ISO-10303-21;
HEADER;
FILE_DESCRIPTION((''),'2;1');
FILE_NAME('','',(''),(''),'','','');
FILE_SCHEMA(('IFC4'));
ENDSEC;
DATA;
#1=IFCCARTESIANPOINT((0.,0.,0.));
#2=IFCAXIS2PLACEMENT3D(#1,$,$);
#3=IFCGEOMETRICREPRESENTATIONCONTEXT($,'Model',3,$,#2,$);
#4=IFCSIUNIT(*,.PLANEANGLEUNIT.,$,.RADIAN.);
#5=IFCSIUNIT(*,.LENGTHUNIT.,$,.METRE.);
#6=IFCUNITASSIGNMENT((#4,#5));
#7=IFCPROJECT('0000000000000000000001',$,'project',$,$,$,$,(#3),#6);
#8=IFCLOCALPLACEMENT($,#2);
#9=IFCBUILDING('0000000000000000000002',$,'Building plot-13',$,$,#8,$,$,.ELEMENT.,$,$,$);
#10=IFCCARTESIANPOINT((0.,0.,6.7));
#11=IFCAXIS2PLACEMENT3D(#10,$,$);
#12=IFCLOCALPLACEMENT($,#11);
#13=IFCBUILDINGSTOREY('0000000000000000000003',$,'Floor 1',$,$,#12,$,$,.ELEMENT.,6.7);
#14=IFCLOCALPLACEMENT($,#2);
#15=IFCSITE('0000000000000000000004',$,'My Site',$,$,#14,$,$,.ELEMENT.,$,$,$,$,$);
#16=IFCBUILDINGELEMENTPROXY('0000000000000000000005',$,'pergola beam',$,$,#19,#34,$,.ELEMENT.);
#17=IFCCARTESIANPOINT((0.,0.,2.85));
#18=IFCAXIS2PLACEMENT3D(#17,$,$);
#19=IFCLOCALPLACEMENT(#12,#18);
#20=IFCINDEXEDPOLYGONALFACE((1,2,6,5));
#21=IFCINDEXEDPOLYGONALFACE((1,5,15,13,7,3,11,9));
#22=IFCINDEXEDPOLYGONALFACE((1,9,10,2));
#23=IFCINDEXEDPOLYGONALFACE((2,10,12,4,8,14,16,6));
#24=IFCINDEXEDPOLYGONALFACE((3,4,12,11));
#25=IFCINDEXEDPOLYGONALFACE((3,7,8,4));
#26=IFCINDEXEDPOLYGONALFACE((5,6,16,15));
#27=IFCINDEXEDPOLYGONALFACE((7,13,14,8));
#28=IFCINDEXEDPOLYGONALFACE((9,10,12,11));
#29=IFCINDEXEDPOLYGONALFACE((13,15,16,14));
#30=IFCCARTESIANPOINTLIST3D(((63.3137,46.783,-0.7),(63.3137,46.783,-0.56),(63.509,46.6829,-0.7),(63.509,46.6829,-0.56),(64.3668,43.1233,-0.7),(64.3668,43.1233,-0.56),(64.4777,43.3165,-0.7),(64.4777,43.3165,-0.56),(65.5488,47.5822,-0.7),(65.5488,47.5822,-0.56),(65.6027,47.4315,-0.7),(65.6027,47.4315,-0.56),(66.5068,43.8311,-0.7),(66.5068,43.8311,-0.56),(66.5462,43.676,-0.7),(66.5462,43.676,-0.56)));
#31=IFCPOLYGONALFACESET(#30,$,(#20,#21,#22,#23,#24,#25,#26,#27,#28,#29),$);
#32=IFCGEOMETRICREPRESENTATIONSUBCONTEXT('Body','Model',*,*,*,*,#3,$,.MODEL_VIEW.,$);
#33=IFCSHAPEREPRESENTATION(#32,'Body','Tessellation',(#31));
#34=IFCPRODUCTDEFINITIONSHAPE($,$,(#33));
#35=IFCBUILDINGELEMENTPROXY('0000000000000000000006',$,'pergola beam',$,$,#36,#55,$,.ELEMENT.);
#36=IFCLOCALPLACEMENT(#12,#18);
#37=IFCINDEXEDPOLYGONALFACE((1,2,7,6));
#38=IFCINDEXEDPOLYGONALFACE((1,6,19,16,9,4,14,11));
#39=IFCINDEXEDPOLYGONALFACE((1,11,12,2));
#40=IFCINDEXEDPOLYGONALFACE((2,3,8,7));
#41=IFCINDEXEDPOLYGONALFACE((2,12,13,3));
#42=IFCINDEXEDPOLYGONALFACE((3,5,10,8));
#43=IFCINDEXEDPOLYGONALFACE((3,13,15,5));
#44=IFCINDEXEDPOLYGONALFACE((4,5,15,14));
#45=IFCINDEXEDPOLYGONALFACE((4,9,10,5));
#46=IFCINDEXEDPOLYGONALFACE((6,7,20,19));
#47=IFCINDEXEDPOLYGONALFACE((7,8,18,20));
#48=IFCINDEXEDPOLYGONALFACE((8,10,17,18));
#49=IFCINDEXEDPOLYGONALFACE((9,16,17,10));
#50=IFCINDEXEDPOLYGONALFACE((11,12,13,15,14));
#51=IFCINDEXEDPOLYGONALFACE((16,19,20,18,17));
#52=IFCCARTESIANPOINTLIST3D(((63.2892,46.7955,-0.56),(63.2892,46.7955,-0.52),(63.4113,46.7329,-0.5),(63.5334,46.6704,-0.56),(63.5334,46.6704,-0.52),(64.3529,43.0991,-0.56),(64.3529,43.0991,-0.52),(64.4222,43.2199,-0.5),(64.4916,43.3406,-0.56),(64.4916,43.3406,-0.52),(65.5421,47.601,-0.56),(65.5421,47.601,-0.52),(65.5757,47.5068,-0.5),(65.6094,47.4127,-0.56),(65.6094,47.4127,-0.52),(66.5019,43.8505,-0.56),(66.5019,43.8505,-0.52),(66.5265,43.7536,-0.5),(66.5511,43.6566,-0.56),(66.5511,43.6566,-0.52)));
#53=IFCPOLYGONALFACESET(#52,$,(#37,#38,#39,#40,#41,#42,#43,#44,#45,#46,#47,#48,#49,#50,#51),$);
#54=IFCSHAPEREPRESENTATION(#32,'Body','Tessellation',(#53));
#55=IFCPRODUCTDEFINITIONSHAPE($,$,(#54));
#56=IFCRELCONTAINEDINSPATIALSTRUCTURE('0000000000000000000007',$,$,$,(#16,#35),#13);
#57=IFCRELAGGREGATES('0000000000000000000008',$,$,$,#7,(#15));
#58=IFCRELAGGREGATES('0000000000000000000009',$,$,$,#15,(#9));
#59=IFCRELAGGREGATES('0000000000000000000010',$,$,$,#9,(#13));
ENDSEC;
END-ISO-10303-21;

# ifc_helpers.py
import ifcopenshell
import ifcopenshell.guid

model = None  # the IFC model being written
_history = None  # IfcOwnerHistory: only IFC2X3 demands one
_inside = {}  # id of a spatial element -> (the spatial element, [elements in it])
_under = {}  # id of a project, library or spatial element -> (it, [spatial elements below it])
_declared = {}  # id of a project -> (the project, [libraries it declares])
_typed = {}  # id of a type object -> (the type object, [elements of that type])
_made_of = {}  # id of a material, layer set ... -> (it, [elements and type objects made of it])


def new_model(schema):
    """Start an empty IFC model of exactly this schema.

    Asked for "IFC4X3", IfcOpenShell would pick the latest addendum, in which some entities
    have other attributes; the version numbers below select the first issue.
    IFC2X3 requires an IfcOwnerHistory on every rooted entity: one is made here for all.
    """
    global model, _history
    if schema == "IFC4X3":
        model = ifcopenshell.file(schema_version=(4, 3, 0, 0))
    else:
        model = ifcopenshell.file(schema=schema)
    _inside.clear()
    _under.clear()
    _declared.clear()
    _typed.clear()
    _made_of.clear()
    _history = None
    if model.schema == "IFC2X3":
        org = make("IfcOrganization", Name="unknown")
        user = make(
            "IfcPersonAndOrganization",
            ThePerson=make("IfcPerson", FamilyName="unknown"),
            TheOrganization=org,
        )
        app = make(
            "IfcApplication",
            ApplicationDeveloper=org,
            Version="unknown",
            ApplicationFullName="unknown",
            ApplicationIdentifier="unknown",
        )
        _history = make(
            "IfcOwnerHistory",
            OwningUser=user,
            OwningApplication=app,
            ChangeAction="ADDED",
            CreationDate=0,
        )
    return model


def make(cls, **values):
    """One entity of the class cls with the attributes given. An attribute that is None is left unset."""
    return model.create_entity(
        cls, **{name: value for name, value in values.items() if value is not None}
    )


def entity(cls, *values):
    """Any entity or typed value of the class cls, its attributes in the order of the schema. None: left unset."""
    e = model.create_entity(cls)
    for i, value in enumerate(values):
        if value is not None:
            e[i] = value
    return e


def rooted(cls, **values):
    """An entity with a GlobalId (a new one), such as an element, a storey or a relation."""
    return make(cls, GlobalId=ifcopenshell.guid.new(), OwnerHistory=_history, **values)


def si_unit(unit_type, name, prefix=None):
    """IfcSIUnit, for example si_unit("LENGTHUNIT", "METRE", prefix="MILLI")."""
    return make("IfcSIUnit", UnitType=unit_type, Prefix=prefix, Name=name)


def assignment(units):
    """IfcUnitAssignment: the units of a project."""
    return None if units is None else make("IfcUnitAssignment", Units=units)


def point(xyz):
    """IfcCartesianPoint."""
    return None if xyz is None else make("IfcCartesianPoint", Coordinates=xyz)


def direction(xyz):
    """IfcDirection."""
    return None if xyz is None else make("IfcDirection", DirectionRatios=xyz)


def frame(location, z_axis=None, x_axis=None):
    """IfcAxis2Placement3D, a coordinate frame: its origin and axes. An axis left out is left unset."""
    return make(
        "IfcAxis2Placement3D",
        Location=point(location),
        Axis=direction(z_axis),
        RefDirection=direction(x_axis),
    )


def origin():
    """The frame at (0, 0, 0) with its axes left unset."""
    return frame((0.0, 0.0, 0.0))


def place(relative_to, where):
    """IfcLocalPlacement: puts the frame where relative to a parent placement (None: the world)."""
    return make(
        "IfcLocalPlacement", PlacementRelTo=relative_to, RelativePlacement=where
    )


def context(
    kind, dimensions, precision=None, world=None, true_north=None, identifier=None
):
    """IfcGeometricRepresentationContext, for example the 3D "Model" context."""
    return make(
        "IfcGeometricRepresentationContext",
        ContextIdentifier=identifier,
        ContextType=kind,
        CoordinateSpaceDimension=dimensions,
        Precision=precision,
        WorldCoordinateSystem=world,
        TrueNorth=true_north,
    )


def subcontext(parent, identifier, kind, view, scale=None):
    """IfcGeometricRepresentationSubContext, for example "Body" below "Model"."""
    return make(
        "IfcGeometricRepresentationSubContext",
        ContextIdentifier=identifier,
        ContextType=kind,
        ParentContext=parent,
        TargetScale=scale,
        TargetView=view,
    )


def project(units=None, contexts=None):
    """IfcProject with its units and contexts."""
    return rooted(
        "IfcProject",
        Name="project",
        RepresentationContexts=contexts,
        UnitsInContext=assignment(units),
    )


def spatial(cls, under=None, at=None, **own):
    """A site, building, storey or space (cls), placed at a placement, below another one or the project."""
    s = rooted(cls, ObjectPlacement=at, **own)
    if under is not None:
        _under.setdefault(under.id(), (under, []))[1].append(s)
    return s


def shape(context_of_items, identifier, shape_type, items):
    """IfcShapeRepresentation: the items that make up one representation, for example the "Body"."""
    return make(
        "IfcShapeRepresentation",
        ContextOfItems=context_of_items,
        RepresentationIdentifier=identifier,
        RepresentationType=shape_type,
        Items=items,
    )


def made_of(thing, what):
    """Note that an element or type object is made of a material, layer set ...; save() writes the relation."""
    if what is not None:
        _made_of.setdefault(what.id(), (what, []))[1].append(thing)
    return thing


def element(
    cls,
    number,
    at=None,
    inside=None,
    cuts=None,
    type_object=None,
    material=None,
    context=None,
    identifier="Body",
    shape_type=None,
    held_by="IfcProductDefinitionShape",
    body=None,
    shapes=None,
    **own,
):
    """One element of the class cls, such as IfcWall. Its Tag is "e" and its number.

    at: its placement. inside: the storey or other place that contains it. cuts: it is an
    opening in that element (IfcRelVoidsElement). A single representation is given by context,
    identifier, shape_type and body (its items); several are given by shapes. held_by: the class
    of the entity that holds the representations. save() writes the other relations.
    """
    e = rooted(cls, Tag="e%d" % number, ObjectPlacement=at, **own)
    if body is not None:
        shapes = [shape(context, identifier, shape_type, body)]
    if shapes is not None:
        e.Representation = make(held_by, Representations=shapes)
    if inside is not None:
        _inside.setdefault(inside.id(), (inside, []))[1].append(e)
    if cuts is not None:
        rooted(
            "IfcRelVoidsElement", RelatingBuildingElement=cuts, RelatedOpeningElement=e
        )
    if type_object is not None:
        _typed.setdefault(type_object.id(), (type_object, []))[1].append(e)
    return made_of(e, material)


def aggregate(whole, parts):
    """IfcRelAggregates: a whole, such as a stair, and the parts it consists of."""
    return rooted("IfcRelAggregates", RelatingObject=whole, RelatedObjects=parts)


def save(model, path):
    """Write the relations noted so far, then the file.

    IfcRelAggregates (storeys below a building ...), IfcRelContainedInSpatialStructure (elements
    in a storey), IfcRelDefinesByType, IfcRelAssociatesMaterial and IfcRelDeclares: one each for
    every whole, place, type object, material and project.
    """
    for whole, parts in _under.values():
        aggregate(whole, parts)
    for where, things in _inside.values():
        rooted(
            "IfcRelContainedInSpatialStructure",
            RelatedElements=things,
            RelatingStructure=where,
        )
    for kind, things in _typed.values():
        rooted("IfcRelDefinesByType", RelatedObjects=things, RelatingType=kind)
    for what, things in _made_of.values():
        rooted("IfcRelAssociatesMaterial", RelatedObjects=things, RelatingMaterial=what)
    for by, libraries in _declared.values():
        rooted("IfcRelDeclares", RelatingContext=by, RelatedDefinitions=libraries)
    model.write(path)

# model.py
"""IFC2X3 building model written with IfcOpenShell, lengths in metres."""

from ifc_helpers import new_model, entity, si_unit, frame, origin, place, context, subcontext, project, spatial, element, save


model = new_model("IFC2X3")

# Units and contexts
model_context = context("Model", 3, world=origin())
body_context = subcontext(model_context, "Body", "Model", "MODEL_VIEW")
ifc_project = project(units=[si_unit("PLANEANGLEUNIT", "RADIAN"), si_unit("LENGTHUNIT", "METRE")], contexts=[model_context])

# Site, building, storey
site_placement = place(None, origin())
site = spatial("IfcSite", under=ifc_project, at=site_placement, Name="My Site", CompositionType="ELEMENT")
building_placement = place(None, origin())
building = spatial("IfcBuilding", under=site, at=building_placement, Name="Building plot-13", CompositionType="ELEMENT")
storey_placement = place(None, frame((0.0, 0.0, 6.7)))
storey = spatial("IfcBuildingStorey", under=building, at=storey_placement, Name="Floor 1", CompositionType="ELEMENT", Elevation=6.7)

# Building element proxies
proxy_1_placement = place(storey_placement, frame((0.0, 0.0, 2.85)))
axis2_placement3_d_1 = entity("IfcAxis2Placement3D", entity("IfcCartesianPoint", [0.0, 0.0, 0.0]))
element("IfcBuildingElementProxy", 1, at=proxy_1_placement, inside=storey, Name="pergola beam", CompositionType="ELEMENT", context=body_context, shape_type="SweptSolid", held_by="IfcProductRepresentation", body=[
    entity("IfcSurfaceCurveSweptAreaSolid", entity("IfcArbitraryClosedProfileDef", "AREA", None, entity("IfcPolyline", [entity("IfcCartesianPoint", [-0.7, -0.08]), entity("IfcCartesianPoint", [-0.7, 0.08]), entity("IfcCartesianPoint", [-0.56, 0.08]), entity("IfcCartesianPoint", [-0.56, -0.08]), entity("IfcCartesianPoint", [-0.7, -0.08])])), axis2_placement3_d_1, entity("IfcPolyline", [entity("IfcCartesianPoint", [65.5757, 47.5068]), entity("IfcCartesianPoint", [63.4113, 46.7329]), entity("IfcCartesianPoint", [64.4222, 43.2199]), entity("IfcCartesianPoint", [66.5265, 43.7536])]), 0.0, 1.0, entity("IfcPlane", axis2_placement3_d_1)),
])
proxy_2_placement = place(storey_placement, frame((0.0, 0.0, 2.85)))
axis2_placement3_d_2 = entity("IfcAxis2Placement3D", entity("IfcCartesianPoint", [0.0, 0.0, 0.0]))
element("IfcBuildingElementProxy", 2, at=proxy_2_placement, inside=storey, Name="pergola beam", CompositionType="ELEMENT", context=body_context, shape_type="SweptSolid", held_by="IfcProductRepresentation", body=[
    entity("IfcSurfaceCurveSweptAreaSolid", entity("IfcArbitraryClosedProfileDef", "AREA", None, entity("IfcPolyline", [entity("IfcCartesianPoint", [-0.5, 0.0]), entity("IfcCartesianPoint", [-0.52, -0.1]), entity("IfcCartesianPoint", [-0.56, -0.1]), entity("IfcCartesianPoint", [-0.56, 0.1]), entity("IfcCartesianPoint", [-0.52, 0.1]), entity("IfcCartesianPoint", [-0.5, 0.0])])), axis2_placement3_d_2, entity("IfcPolyline", [entity("IfcCartesianPoint", [65.5757, 47.5068]), entity("IfcCartesianPoint", [63.4113, 46.7329]), entity("IfcCartesianPoint", [64.4222, 43.2199]), entity("IfcCartesianPoint", [66.5265, 43.7536])]), 0.0, 1.0, entity("IfcPlane", axis2_placement3_d_2)),
])

save(model, "model.ifc")
